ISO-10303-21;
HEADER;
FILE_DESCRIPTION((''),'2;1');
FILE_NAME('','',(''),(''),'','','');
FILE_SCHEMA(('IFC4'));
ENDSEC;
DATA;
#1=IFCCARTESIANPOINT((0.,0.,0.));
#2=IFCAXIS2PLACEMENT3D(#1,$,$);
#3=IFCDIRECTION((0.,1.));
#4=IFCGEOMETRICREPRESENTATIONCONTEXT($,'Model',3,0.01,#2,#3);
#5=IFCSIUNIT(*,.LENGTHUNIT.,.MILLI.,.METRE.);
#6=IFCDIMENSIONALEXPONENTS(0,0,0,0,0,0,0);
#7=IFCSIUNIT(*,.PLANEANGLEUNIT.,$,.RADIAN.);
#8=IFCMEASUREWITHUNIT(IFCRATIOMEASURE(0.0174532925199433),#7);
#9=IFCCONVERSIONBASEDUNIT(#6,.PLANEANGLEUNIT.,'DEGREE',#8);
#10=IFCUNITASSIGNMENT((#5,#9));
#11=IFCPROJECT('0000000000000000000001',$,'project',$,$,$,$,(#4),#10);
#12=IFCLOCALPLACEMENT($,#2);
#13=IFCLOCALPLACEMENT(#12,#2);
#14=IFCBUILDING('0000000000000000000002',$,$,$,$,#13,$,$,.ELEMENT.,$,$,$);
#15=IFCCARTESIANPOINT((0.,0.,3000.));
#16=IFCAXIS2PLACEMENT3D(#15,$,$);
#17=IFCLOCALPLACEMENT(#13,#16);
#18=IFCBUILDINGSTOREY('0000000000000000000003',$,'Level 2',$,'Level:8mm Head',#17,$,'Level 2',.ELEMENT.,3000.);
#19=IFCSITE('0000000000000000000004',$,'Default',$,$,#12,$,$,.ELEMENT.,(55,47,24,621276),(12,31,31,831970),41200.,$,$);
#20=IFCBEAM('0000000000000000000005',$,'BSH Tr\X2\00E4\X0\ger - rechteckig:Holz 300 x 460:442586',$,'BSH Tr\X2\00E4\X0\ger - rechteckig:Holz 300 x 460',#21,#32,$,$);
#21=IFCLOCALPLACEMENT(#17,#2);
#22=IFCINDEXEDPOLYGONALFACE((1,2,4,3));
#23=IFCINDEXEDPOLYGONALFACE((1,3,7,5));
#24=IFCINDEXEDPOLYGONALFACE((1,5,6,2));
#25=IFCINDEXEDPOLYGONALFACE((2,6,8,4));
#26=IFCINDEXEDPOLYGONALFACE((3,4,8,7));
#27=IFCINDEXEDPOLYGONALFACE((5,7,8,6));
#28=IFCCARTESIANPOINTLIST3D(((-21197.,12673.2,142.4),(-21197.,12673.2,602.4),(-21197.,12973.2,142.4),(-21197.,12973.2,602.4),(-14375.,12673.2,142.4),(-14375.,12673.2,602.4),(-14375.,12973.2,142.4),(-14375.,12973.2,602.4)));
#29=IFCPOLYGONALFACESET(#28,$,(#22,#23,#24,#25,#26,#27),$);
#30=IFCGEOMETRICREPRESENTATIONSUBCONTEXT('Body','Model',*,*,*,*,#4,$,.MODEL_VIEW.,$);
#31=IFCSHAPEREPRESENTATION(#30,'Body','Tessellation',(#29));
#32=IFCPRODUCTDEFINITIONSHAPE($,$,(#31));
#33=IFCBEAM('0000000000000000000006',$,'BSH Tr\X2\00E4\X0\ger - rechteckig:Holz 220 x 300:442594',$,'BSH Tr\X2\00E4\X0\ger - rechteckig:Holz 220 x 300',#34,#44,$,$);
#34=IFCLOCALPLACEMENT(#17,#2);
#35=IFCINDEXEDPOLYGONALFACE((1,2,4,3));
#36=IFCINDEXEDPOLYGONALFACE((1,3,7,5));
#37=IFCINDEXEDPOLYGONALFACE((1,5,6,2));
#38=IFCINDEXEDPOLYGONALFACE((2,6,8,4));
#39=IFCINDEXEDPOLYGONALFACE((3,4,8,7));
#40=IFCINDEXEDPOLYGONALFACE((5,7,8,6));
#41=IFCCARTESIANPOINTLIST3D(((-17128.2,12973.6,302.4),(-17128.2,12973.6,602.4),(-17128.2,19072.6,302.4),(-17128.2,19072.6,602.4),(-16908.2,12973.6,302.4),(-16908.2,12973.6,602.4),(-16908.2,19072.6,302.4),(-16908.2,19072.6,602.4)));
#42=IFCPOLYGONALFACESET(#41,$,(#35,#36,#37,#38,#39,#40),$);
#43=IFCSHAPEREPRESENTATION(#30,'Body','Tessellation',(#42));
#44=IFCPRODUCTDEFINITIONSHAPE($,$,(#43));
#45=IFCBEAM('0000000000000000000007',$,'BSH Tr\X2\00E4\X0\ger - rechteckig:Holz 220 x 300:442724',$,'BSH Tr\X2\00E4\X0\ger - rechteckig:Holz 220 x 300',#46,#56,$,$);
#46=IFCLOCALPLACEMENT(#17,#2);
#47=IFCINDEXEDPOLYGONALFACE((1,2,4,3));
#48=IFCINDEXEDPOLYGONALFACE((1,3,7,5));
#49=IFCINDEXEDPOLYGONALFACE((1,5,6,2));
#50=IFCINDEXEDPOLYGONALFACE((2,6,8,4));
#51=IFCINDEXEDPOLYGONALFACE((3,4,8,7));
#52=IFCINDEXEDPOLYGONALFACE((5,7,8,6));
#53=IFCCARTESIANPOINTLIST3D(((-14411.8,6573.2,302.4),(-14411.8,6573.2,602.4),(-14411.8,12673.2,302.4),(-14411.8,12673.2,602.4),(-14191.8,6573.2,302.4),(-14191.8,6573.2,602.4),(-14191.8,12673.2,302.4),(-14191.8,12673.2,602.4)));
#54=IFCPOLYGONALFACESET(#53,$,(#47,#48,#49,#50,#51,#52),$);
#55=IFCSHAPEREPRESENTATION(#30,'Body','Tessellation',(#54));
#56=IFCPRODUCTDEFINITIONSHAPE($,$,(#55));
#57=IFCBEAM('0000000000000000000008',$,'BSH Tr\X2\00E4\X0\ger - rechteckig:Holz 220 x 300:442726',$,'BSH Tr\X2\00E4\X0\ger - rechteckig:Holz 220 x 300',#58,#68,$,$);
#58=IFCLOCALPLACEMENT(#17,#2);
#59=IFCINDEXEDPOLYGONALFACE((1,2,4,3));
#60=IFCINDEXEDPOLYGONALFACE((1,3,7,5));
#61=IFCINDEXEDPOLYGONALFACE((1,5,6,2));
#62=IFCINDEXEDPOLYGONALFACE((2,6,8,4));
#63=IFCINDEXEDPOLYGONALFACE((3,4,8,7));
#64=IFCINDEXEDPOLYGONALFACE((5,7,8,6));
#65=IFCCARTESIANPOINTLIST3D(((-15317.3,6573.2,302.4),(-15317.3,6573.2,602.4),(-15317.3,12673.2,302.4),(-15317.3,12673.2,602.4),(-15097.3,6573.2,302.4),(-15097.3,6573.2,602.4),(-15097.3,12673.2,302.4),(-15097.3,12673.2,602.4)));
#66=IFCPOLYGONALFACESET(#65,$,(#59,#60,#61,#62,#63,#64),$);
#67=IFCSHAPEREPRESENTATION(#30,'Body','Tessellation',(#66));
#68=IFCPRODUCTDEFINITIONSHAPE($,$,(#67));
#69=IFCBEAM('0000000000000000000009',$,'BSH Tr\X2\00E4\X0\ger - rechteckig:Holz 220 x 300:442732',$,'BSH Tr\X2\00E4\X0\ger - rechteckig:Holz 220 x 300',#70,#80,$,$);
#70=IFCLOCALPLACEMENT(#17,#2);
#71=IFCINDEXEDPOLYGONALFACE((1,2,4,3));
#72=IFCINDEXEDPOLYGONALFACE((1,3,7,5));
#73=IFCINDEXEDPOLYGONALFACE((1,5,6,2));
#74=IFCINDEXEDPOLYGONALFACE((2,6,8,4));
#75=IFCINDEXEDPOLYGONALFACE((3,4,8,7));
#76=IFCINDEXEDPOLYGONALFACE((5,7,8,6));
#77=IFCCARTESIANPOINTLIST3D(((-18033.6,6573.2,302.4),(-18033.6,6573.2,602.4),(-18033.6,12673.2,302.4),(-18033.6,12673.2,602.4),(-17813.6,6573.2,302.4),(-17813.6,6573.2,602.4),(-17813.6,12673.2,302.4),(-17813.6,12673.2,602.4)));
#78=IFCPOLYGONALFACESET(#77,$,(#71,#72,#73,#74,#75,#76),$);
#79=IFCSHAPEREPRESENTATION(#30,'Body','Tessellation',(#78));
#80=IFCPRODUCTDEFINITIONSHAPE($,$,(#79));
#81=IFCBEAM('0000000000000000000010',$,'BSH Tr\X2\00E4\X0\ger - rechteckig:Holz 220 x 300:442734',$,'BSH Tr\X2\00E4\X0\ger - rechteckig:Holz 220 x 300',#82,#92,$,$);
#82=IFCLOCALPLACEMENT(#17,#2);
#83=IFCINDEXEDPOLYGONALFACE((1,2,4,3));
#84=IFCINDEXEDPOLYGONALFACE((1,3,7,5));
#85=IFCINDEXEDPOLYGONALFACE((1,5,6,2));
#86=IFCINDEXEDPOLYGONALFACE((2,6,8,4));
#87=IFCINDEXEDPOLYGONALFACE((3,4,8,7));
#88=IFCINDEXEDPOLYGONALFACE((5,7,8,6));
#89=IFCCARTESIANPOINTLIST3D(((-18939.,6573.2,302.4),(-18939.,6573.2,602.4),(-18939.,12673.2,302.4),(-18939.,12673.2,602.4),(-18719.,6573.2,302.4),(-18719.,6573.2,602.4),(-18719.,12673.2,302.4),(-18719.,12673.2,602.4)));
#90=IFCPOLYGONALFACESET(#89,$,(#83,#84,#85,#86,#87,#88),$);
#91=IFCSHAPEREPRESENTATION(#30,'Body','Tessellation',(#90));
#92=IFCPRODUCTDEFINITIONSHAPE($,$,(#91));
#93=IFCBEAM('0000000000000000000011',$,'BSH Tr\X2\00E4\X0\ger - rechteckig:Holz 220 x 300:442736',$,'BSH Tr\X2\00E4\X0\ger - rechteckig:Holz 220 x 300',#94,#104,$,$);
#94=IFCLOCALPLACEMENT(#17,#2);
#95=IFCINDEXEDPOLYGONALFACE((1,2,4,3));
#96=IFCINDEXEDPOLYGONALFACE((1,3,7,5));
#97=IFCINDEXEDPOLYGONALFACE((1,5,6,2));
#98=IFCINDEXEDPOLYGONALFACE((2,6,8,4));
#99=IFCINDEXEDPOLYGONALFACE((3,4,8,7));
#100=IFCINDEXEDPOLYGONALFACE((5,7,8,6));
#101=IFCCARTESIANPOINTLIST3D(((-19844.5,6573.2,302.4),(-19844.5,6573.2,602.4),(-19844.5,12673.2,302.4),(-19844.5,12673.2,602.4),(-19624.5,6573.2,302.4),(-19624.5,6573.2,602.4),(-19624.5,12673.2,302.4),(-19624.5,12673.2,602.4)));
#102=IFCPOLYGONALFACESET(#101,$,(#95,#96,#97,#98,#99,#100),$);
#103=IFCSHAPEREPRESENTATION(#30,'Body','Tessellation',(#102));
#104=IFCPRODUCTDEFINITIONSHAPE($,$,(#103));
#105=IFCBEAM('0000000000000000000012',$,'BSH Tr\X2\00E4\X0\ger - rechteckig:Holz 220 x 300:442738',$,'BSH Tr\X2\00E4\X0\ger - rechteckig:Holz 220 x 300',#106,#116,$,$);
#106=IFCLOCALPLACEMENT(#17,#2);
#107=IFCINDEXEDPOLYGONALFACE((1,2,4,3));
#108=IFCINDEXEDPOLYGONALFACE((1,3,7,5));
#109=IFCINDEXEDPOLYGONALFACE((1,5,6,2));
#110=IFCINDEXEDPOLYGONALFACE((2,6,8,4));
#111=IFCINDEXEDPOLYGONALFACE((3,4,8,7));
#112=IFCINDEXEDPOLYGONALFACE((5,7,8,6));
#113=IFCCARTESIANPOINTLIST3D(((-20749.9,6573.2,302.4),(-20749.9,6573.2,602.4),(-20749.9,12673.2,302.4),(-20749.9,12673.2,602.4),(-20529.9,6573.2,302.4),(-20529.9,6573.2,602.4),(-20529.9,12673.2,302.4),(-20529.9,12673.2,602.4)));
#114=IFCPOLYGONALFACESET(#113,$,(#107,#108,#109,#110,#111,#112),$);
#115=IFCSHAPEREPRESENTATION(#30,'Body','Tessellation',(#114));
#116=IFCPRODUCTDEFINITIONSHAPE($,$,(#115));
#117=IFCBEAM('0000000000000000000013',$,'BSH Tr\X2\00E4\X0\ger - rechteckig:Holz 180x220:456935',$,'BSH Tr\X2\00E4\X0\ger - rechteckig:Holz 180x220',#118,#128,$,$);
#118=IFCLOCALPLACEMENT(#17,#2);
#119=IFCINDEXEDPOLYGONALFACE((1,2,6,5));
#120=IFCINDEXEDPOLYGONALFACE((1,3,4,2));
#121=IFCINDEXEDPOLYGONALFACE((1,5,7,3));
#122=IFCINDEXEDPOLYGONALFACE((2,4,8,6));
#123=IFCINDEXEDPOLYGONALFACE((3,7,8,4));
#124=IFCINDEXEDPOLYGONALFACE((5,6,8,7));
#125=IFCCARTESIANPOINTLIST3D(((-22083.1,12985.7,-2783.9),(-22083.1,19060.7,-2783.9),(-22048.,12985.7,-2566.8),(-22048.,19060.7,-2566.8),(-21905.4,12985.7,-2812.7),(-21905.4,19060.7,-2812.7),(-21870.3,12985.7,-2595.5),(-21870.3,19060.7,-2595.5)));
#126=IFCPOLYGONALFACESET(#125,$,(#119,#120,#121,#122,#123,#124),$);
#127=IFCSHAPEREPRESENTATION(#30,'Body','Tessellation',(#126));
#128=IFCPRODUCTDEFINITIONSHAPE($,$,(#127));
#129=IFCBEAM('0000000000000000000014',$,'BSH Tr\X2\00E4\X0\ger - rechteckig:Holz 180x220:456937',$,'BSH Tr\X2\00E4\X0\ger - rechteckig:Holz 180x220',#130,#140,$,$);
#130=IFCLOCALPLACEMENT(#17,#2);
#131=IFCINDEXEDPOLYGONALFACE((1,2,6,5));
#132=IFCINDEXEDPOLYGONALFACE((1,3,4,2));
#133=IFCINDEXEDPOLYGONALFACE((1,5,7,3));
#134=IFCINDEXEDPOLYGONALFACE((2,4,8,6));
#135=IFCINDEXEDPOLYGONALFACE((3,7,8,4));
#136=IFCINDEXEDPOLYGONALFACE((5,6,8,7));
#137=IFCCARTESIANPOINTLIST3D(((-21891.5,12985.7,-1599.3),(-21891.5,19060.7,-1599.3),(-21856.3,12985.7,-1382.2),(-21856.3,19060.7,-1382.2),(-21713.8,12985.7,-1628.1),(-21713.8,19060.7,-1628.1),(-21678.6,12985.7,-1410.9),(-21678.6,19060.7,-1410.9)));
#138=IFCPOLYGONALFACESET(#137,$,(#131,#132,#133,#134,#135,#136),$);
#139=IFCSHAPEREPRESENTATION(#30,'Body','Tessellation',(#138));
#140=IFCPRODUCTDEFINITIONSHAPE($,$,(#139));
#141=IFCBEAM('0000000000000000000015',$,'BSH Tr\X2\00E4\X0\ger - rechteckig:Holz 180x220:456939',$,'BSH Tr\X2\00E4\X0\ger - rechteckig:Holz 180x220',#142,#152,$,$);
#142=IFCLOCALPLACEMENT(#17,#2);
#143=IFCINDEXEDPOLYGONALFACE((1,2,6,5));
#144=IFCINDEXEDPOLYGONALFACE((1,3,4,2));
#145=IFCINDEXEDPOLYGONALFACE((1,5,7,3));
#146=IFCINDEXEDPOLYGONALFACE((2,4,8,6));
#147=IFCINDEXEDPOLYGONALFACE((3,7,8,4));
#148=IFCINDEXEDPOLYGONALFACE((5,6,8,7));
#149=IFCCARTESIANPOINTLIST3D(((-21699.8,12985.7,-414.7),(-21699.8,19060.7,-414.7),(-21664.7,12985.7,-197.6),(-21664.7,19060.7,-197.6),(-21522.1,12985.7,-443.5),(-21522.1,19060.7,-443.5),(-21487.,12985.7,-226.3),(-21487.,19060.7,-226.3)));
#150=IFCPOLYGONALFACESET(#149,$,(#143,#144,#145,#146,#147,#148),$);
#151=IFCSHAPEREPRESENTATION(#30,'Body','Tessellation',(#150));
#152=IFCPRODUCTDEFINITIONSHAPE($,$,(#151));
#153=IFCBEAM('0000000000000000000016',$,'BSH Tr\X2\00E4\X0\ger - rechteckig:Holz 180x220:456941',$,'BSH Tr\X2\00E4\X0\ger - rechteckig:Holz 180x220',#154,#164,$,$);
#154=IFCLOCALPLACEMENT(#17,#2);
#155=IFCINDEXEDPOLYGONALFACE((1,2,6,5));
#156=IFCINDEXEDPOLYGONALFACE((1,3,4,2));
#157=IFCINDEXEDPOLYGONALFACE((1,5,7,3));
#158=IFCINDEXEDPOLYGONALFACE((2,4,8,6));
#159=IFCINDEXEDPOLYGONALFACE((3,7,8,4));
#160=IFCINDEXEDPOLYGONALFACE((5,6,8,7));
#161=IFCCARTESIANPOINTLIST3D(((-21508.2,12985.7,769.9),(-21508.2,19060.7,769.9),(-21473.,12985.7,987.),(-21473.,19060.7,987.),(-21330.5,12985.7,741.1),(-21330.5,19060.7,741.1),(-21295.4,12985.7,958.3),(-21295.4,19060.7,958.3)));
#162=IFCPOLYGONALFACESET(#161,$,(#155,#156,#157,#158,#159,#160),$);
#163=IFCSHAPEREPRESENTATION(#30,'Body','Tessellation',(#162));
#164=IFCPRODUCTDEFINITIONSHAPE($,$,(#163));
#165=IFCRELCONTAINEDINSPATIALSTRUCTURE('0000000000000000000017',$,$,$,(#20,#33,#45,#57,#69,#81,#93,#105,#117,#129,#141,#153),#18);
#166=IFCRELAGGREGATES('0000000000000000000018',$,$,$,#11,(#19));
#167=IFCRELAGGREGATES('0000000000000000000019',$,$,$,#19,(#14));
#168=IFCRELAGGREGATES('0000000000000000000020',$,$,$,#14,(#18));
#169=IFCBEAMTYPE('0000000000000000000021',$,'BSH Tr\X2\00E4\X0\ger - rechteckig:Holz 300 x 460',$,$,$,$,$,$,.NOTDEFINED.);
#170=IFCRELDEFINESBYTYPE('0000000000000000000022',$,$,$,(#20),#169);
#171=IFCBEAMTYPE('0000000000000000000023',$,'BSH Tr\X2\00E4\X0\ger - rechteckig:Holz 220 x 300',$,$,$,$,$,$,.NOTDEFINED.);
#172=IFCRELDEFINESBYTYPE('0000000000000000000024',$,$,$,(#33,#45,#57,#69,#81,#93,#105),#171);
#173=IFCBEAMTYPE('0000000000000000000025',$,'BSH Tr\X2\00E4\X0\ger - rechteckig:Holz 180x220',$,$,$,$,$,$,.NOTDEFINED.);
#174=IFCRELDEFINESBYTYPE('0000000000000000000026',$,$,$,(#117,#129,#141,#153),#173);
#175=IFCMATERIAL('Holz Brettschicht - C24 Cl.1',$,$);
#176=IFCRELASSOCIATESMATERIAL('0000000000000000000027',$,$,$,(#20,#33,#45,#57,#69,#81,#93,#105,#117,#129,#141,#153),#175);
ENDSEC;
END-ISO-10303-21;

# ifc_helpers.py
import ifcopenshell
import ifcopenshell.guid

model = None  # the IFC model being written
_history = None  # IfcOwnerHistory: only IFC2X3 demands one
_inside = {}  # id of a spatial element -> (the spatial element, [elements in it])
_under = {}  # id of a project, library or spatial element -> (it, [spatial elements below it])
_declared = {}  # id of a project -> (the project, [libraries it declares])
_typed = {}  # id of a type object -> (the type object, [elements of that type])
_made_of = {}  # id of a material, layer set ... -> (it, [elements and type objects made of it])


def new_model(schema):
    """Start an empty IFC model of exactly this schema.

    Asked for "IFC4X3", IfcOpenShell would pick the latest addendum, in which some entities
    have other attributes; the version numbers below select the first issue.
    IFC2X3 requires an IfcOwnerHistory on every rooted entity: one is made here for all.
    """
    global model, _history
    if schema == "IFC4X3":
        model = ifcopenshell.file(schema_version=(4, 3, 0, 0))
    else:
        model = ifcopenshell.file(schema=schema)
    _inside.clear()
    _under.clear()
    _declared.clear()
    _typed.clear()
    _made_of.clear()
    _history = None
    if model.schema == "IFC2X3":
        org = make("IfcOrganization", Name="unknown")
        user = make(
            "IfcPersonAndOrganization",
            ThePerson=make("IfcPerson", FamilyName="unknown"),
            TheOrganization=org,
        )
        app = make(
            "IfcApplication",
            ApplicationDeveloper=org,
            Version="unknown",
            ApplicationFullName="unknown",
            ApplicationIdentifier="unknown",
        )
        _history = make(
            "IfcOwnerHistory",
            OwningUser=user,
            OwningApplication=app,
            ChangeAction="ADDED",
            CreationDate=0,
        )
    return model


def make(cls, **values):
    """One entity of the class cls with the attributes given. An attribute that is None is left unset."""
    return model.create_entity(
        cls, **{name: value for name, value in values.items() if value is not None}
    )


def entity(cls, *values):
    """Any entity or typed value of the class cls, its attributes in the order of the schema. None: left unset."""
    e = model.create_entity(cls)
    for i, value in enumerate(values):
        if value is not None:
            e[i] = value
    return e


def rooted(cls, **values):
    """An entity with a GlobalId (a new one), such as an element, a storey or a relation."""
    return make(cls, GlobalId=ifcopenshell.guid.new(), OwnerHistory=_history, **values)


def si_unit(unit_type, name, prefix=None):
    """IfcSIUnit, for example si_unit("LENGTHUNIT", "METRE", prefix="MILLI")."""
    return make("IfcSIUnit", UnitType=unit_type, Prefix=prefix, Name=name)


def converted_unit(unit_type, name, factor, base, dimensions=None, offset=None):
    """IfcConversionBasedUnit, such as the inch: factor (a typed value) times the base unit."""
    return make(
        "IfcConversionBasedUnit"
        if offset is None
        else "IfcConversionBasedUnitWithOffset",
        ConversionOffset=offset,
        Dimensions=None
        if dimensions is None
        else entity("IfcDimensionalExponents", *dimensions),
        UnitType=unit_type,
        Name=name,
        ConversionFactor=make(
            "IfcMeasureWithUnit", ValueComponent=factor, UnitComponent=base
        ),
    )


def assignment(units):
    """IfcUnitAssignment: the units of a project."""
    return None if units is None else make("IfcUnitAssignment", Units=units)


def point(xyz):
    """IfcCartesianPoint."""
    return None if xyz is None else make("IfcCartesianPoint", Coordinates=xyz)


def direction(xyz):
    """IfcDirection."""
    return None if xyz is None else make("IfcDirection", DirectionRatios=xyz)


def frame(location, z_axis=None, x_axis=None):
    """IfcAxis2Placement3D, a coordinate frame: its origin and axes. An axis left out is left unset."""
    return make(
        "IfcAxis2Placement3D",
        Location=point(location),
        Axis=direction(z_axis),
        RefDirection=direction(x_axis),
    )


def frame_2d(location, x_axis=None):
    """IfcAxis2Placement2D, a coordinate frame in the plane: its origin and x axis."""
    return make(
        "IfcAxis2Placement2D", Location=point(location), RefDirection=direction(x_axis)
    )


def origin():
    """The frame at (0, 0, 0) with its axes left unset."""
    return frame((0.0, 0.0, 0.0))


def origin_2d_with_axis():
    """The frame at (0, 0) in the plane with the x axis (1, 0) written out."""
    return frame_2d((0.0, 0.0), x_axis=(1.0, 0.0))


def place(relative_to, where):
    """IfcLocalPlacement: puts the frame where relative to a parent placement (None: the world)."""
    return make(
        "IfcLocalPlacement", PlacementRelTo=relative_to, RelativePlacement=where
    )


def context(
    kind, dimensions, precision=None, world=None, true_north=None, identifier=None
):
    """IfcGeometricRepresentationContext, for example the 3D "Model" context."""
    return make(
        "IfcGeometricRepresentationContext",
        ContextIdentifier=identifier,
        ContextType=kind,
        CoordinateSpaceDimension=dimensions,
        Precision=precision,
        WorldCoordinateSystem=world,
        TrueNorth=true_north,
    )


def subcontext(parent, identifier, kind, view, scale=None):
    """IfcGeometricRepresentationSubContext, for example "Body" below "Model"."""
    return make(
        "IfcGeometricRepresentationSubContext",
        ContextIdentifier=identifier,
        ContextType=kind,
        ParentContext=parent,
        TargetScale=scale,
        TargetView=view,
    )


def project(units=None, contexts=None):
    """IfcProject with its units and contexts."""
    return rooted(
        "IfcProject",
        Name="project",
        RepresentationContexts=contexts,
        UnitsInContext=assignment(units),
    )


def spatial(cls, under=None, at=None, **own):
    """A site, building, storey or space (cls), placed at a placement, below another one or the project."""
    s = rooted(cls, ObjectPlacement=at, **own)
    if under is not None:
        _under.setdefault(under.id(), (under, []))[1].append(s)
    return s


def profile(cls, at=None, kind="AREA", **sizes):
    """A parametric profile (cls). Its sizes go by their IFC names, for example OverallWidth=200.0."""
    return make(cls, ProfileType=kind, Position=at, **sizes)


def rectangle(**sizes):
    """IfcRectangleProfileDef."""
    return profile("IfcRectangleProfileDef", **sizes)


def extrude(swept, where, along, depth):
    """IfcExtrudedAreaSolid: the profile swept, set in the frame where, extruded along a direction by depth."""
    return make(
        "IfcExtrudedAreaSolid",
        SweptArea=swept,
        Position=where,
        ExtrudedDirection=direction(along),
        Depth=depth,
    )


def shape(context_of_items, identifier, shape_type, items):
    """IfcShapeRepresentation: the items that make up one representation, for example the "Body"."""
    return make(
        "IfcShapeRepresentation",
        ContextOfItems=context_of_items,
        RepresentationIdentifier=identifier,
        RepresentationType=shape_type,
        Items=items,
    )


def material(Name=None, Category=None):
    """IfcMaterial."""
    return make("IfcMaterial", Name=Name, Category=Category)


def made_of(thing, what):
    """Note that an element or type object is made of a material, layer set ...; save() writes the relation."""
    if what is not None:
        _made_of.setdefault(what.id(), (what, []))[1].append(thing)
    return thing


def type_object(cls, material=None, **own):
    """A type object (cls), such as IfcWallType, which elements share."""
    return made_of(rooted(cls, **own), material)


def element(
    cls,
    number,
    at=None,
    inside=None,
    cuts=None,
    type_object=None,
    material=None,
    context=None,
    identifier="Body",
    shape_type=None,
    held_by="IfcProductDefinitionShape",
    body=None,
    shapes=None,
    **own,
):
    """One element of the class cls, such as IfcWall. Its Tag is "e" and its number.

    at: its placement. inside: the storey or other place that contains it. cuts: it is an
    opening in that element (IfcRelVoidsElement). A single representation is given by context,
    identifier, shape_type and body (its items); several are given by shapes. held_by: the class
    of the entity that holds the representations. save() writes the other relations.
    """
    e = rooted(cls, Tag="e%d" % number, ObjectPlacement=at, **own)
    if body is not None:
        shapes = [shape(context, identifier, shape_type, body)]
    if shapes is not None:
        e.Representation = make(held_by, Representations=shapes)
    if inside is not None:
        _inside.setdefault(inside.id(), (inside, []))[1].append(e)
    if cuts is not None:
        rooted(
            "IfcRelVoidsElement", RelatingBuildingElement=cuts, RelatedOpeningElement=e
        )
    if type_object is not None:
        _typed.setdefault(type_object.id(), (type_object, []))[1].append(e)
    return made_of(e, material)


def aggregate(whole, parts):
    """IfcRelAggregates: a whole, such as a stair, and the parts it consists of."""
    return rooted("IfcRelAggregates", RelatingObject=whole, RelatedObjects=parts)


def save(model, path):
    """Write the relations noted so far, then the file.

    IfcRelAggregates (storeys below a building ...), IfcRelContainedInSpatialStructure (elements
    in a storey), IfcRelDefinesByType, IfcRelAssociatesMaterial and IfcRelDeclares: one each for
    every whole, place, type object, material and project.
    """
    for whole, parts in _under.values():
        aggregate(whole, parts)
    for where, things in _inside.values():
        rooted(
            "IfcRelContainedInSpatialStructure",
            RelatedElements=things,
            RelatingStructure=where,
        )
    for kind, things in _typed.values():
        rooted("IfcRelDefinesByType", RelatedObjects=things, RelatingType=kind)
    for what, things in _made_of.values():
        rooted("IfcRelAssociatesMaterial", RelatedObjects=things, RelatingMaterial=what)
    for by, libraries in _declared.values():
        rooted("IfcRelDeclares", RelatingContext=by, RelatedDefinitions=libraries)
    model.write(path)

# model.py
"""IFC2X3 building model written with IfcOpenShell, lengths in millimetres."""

from ifc_helpers import new_model, entity, si_unit, converted_unit, direction, frame, frame_2d, origin, origin_2d_with_axis, place, context, subcontext, project, spatial, rectangle, extrude, material, type_object, element, save


model = new_model("IFC2X3")

# Units and contexts
model_context = context("Model", 3, precision=0.01, world=origin(), true_north=direction((0.0, 1.0)))
body_context = subcontext(model_context, "Body", "Model", "MODEL_VIEW")
ifc_project = project(units=[si_unit("LENGTHUNIT", "METRE", prefix="MILLI"), converted_unit("PLANEANGLEUNIT", "DEGREE", entity("IfcRatioMeasure", 0.0174532925199433), si_unit("PLANEANGLEUNIT", "RADIAN"), dimensions=[0, 0, 0, 0, 0, 0, 0])], contexts=[model_context])

# Site, building, storey
site_placement = place(None, origin())
site = spatial("IfcSite", under=ifc_project, at=site_placement, Name="Default", CompositionType="ELEMENT", RefLatitude=(55, 47, 24, 621276), RefLongitude=(12, 31, 31, 831970), RefElevation=41200.0)
building_placement = place(site_placement, origin())
building = spatial("IfcBuilding", under=site, at=building_placement, CompositionType="ELEMENT")
storey_placement = place(building_placement, frame((0.0, 0.0, 3000.0)))
storey = spatial("IfcBuildingStorey", under=building, at=storey_placement, Name="Level 2", ObjectType="Level:8mm Head", LongName="Level 2", CompositionType="ELEMENT", Elevation=3000.0)

# Beams
ifc_material = material(Name="Holz Brettschicht - C24 Cl.1")
beam_type_1 = type_object("IfcBeamType", Name="BSH Träger - rechteckig:Holz 300 x 460", PredefinedType="NOTDEFINED")
beam_1_placement = place(storey_placement, frame((-14041.8, 12823.2, 602.4), z_axis=(0.0, 0.0, 1.0), x_axis=(-1.0, 0.0, 0.0)))
element("IfcBeam", 1, at=beam_1_placement, inside=storey, type_object=beam_type_1, material=ifc_material, Name="BSH Träger - rechteckig:Holz 300 x 460:442586", ObjectType="BSH Träger - rechteckig:Holz 300 x 460", context=body_context, shape_type="SweptSolid", body=[
    extrude(rectangle(XDim=460.0, YDim=300.0, at=frame_2d((0.0, 0.0), x_axis=(1.0, 0.0))), frame((333.2, 0.0, -230.0), z_axis=(1.0, 0.0, 0.0), x_axis=(0.0, 0.0, -1.0)), (0.0, 0.0, 1.0), 6822.0),
])
beam_type_2 = type_object("IfcBeamType", Name="BSH Träger - rechteckig:Holz 220 x 300", PredefinedType="NOTDEFINED")
beam_2_placement = place(storey_placement, frame((-17018.2, 19136.0, 602.4), z_axis=(0.0, 0.0, 1.0), x_axis=(0.0, -1.0, 0.0)))
element("IfcBeam", 2, at=beam_2_placement, inside=storey, type_object=beam_type_2, material=ifc_material, Name="BSH Träger - rechteckig:Holz 220 x 300:442594", ObjectType="BSH Träger - rechteckig:Holz 220 x 300", context=body_context, shape_type="SweptSolid", body=[
    extrude(rectangle(XDim=300.0, YDim=220.0, at=frame_2d((0.0, 0.0), x_axis=(1.0, 0.0))), frame((63.4, 0.0, -150.0), z_axis=(1.0, 0.0, 0.0), x_axis=(0.0, 0.0, -1.0)), (0.0, 0.0, 1.0), 6099.0),
])
for number, where, z_axis, x_axis, name in (
    (3, (-14301.8, 12823.2, 602.4), (0.0, 0.0, 1.0), (0.0, -1.0, 0.0), "BSH Träger - rechteckig:Holz 220 x 300:442724"),
    (4, (-15207.3, 12823.2, 602.4), (0.0, 0.0, 1.0), (0.0, -1.0, 0.0), "BSH Träger - rechteckig:Holz 220 x 300:442726"),
):
    element("IfcBeam", number, at=place(storey_placement, frame(where, z_axis=z_axis, x_axis=x_axis)), inside=storey, type_object=beam_type_2, material=ifc_material, Name=name, ObjectType="BSH Träger - rechteckig:Holz 220 x 300", context=body_context, shape_type="SweptSolid", body=[
        extrude(rectangle(XDim=300.0, YDim=220.0, at=frame_2d((0.0, 0.0), x_axis=(1.0, 0.0))), frame((150.0, 0.0, -150.0), z_axis=(1.0, 0.0, 0.0), x_axis=(0.0, 0.0, -1.0)), (0.0, 0.0, 1.0), 6100.0),
    ])
for number, where, z_axis, x_axis, name in (
    (5, (-17923.6, 12823.2, 602.4), (0.0, 0.0, 1.0), (0.0, -1.0, 0.0), "BSH Träger - rechteckig:Holz 220 x 300:442732"),
    (6, (-18829.0, 12823.2, 602.4), (0.0, 0.0, 1.0), (0.0, -1.0, 0.0), "BSH Träger - rechteckig:Holz 220 x 300:442734"),
):
    element("IfcBeam", number, at=place(storey_placement, frame(where, z_axis=z_axis, x_axis=x_axis)), inside=storey, type_object=beam_type_2, material=ifc_material, Name=name, ObjectType="BSH Träger - rechteckig:Holz 220 x 300", context=body_context, shape_type="SweptSolid", body=[
        extrude(rectangle(XDim=300.0, YDim=220.0, at=frame_2d((0.0, 0.0), x_axis=(1.0, 0.0))), frame((150.0, 0.0, -150.0), z_axis=(1.0, 0.0, 0.0), x_axis=(0.0, 0.0, -1.0)), (0.0, 0.0, 1.0), 6100.0),
    ])
for number, where, z_axis, x_axis, name in (
    (7, (-19734.5, 12823.2, 602.4), (0.0, 0.0, 1.0), (0.0, -1.0, 0.0), "BSH Träger - rechteckig:Holz 220 x 300:442736"),
    (8, (-20639.9, 12823.2, 602.4), (0.0, 0.0, 1.0), (0.0, -1.0, 0.0), "BSH Träger - rechteckig:Holz 220 x 300:442738"),
):
    element("IfcBeam", number, at=place(storey_placement, frame(where, z_axis=z_axis, x_axis=x_axis)), inside=storey, type_object=beam_type_2, material=ifc_material, Name=name, ObjectType="BSH Träger - rechteckig:Holz 220 x 300", context=body_context, shape_type="SweptSolid", body=[
        extrude(rectangle(XDim=300.0, YDim=220.0, at=origin_2d_with_axis()), frame((150.0, 0.0, -150.0), z_axis=(1.0, 0.0, 0.0), x_axis=(0.0, 0.0, -1.0)), (0.0, 0.0, 1.0), 6100.0),
    ])
beam_type_3 = type_object("IfcBeamType", Name="BSH Träger - rechteckig:Holz 180x220", PredefinedType="NOTDEFINED")
beam_3_placement = place(storey_placement, frame((-22048.0, 18623.2, -2566.8), z_axis=(0.0, 0.0, 1.0), x_axis=(0.0, -1.0, 0.0)))
element("IfcBeam", 9, at=beam_3_placement, inside=storey, type_object=beam_type_3, material=ifc_material, Name="BSH Träger - rechteckig:Holz 180x220:456935", ObjectType="BSH Träger - rechteckig:Holz 180x220", context=body_context, shape_type="SweptSolid", body=[
    extrude(rectangle(XDim=220.0, YDim=180.0, at=frame_2d((0.0, 0.0), x_axis=(1.0, 0.0))), frame((-437.5, 71.3, -123.0), z_axis=(1.0, 0.0, 0.0), x_axis=(0.0, 0.159701, 0.987165)), (0.0, 0.0, 1.0), 6075.0),
])
beam_4_placement = place(storey_placement, frame((-21856.3, 18623.2, -1382.2), z_axis=(0.0, 0.0, 1.0), x_axis=(0.0, -1.0, 0.0)))
element("IfcBeam", 10, at=beam_4_placement, inside=storey, type_object=beam_type_3, material=ifc_material, Name="BSH Träger - rechteckig:Holz 180x220:456937", ObjectType="BSH Träger - rechteckig:Holz 180x220", context=body_context, shape_type="SweptSolid", body=[
    extrude(rectangle(XDim=220.0, YDim=180.0, at=frame_2d((0.0, 0.0), x_axis=(1.0, 0.0))), frame((-437.5, 71.3, -123.0), z_axis=(1.0, 0.0, 0.0), x_axis=(0.0, 0.159701, 0.987165)), (0.0, 0.0, 1.0), 6075.0),
])
beam_5_placement = place(storey_placement, frame((-21664.7, 18623.2, -197.6), z_axis=(0.0, 0.0, 1.0), x_axis=(0.0, -1.0, 0.0)))
element("IfcBeam", 11, at=beam_5_placement, inside=storey, type_object=beam_type_3, material=ifc_material, Name="BSH Träger - rechteckig:Holz 180x220:456939", ObjectType="BSH Träger - rechteckig:Holz 180x220", context=body_context, shape_type="SweptSolid", body=[
    extrude(rectangle(XDim=220.0, YDim=180.0, at=frame_2d((0.0, 0.0), x_axis=(1.0, 0.0))), frame((-437.5, 71.3, -123.0), z_axis=(1.0, 0.0, 0.0), x_axis=(0.0, 0.159701, 0.987165)), (0.0, 0.0, 1.0), 6075.0),
])
beam_6_placement = place(storey_placement, frame((-21473.0, 18623.2, 987.0), z_axis=(0.0, 0.0, 1.0), x_axis=(0.0, -1.0, 0.0)))
element("IfcBeam", 12, at=beam_6_placement, inside=storey, type_object=beam_type_3, material=ifc_material, Name="BSH Träger - rechteckig:Holz 180x220:456941", ObjectType="BSH Träger - rechteckig:Holz 180x220", context=body_context, shape_type="SweptSolid", body=[
    extrude(rectangle(XDim=220.0, YDim=180.0, at=frame_2d((0.0, 0.0), x_axis=(1.0, 0.0))), frame((-437.5, 71.3, -123.0), z_axis=(1.0, 0.0, 0.0), x_axis=(0.0, 0.159701, 0.987165)), (0.0, 0.0, 1.0), 6075.0),
])

save(model, "model.ifc")
